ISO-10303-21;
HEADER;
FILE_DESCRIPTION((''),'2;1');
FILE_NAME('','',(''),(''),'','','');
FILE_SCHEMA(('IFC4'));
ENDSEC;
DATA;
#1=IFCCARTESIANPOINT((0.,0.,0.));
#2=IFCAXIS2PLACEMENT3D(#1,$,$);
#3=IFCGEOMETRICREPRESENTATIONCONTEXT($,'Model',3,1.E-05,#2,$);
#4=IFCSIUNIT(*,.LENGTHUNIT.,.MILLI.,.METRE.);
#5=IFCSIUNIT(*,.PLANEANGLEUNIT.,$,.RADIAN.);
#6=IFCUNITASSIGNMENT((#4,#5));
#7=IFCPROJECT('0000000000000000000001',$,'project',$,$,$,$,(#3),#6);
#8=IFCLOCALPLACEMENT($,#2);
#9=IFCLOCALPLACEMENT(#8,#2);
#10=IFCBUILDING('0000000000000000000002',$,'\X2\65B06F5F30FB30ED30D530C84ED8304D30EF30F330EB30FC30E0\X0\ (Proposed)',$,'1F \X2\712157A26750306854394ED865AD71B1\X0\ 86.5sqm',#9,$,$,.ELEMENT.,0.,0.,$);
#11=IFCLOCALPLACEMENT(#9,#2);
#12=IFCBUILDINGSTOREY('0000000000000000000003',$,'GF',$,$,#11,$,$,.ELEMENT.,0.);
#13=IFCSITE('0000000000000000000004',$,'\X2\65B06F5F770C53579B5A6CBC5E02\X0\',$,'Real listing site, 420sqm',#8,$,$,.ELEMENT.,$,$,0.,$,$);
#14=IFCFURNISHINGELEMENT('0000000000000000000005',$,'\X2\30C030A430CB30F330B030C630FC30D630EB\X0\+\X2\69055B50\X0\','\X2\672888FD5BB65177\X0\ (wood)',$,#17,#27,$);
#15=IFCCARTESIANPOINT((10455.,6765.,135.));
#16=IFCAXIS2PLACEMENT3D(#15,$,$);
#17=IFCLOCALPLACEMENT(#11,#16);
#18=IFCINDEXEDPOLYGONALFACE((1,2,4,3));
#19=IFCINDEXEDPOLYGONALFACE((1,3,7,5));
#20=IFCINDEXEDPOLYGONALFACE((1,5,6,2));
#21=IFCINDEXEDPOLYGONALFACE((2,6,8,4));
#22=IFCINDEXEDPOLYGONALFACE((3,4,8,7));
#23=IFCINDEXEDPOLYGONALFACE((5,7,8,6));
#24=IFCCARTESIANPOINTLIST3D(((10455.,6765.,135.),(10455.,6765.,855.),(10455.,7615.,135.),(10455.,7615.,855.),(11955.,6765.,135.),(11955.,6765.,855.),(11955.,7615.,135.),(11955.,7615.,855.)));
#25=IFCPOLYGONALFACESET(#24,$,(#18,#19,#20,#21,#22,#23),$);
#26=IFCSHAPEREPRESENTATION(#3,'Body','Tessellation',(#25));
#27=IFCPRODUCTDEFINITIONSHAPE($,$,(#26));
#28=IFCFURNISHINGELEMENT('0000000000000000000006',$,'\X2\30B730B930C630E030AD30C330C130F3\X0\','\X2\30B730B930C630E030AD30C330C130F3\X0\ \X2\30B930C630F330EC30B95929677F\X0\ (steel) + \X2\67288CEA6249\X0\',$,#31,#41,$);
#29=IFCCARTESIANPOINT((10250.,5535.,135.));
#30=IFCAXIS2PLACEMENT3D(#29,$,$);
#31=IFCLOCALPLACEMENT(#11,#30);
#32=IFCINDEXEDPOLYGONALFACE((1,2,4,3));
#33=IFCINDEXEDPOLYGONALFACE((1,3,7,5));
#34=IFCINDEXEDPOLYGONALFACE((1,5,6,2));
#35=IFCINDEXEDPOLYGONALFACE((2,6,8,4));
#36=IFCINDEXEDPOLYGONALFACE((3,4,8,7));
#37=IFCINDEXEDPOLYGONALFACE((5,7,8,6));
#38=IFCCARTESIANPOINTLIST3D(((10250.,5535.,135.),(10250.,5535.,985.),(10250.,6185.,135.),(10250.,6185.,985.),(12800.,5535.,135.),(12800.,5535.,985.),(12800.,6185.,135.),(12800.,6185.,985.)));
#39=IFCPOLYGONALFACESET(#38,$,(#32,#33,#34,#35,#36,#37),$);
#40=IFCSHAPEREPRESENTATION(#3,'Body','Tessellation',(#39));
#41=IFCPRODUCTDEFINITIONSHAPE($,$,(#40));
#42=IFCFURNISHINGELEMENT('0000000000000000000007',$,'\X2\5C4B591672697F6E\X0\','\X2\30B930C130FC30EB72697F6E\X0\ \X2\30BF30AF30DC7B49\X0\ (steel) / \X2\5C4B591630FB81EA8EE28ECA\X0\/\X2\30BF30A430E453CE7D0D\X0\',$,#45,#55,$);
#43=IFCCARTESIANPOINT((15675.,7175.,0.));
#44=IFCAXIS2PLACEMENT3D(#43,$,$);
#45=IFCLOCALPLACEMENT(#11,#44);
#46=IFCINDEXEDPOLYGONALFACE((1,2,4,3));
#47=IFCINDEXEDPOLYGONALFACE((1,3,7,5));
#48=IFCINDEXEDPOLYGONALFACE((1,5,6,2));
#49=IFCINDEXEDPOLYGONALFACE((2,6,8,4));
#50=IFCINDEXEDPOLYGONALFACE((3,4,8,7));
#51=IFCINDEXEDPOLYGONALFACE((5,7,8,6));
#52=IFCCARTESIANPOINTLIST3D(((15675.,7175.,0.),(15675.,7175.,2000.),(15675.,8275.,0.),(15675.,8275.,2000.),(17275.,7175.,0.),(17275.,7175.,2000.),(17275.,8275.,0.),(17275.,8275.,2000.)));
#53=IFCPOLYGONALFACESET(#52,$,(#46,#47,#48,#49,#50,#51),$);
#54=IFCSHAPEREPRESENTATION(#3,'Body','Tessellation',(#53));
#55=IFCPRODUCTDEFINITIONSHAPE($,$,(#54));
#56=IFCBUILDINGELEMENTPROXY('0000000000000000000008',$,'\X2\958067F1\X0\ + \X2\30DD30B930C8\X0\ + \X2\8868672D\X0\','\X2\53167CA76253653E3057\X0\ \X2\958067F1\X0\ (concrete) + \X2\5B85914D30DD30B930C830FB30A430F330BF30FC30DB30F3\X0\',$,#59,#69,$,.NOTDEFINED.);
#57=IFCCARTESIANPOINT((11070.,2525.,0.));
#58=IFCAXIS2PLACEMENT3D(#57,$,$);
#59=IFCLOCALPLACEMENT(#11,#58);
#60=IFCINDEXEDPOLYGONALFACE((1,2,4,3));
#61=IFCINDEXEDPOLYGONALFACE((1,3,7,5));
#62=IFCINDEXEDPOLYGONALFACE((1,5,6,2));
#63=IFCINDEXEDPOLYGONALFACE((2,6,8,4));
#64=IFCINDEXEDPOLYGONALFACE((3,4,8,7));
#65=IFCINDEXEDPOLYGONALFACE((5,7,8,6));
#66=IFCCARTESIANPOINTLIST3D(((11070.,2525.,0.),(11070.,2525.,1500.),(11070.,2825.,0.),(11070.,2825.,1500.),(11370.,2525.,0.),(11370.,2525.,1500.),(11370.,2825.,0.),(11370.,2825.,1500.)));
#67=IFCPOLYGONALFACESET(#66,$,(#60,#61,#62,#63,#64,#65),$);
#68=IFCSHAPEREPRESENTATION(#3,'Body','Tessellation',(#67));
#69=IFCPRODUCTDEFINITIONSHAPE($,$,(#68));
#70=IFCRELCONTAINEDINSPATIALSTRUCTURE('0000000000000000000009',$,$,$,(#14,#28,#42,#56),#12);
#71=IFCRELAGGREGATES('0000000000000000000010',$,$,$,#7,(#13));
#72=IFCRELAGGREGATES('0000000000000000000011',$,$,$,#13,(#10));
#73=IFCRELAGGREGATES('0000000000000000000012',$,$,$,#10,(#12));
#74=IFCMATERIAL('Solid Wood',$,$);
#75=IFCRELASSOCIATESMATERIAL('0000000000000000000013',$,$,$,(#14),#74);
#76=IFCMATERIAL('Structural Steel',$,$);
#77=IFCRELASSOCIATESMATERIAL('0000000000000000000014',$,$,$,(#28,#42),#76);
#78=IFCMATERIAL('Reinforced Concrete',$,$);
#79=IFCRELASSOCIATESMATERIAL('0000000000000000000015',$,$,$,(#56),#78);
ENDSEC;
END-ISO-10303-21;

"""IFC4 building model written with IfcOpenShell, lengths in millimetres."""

from ifc_helpers import new_model, si_unit, frame, frame_2d, origin, place, context, project, spatial, rectangle, extrude, material, element, save


model = new_model("IFC4")

# Units and contexts
model_context = context("Model", 3, precision=1e-05, world=origin())
ifc_project = project(units=[si_unit("LENGTHUNIT", "METRE", prefix="MILLI"), si_unit("PLANEANGLEUNIT", "RADIAN")], contexts=[model_context])

# Site, building, storey
site_placement = place(None, origin())
site = spatial("IfcSite", under=ifc_project, at=site_placement, Name="新潟県南魚沼市", ObjectType="Real listing site, 420sqm", CompositionType="ELEMENT", RefElevation=0.0)
building_placement = place(site_placement, origin())
building = spatial("IfcBuilding", under=site, at=building_placement, Name="新潟・ロフト付きワンルーム (Proposed)", ObjectType="1F 無垢材と吹付断熱 86.5sqm", CompositionType="ELEMENT", ElevationOfRefHeight=0.0, ElevationOfTerrain=0.0)
storey_placement = place(building_placement, origin())
storey = spatial("IfcBuildingStorey", under=building, at=storey_placement, Name="GF", CompositionType="ELEMENT", Elevation=0.0)

# Shared definitions
ifc_material_1 = material(Name="Solid Wood")

# Shared definitions
ifc_material_2 = material(Name="Reinforced Concrete")

# Shared definitions
ifc_material_3 = material(Name="Structural Steel")

# Furnishing elements
furnishing_1_placement = place(storey_placement, frame((10455.0, 6765.0, 135.0)))
element("IfcFurnishingElement", 1, at=furnishing_1_placement, inside=storey, material=ifc_material_1, Name="ダイニングテーブル+椅子", Description="木製家具 (wood)", context=model_context, shape_type="SweptSolid", body=[
    extrude(rectangle(XDim=1500.0, YDim=850.0, at=frame_2d((750.0, 425.0))), frame((10455.0, 6765.0, 135.0)), (0.0, 0.0, 1.0), 720.0),
])
furnishing_2_placement = place(storey_placement, frame((10250.0, 5535.0, 135.0)))
element("IfcFurnishingElement", 2, at=furnishing_2_placement, inside=storey, material=ifc_material_3, Name="システムキッチン", Description="システムキッチン ステンレス天板 (steel) + 木質扉", context=model_context, shape_type="SweptSolid", body=[
    extrude(rectangle(XDim=2550.0, YDim=650.0, at=frame_2d((1275.0, 325.0))), frame((10250.0, 5535.0, 135.0)), (0.0, 0.0, 1.0), 850.0),
])
furnishing_3_placement = place(storey_placement, frame((15675.0, 7175.0, 0.0)))
element("IfcFurnishingElement", 3, at=furnishing_3_placement, inside=storey, material=ifc_material_3, Name="屋外物置", Description="スチール物置 タクボ等 (steel) / 屋外・自転車/タイヤ収納", context=model_context, shape_type="SweptSolid", body=[
    extrude(rectangle(XDim=1600.0, YDim=1100.0, at=frame_2d((800.0, 550.0))), frame((15675.0, 7175.0, 0.0)), (0.0, 0.0, 1.0), 2000.0),
])

# Building element proxy
proxy_placement = place(storey_placement, frame((11070.0, 2525.0, 0.0)))
element("IfcBuildingElementProxy", 4, at=proxy_placement, inside=storey, material=ifc_material_2, Name="門柱 + ポスト + 表札", Description="化粧打放し 門柱 (concrete) + 宅配ポスト・インターホン", PredefinedType="NOTDEFINED", context=model_context, shape_type="SweptSolid", body=[
    extrude(rectangle(XDim=300.0, YDim=300.0, at=frame_2d((150.0, 150.0))), frame((11070.0, 2525.0, 0.0)), (0.0, 0.0, 1.0), 1500.0),
])

save(model, "model.ifc")
